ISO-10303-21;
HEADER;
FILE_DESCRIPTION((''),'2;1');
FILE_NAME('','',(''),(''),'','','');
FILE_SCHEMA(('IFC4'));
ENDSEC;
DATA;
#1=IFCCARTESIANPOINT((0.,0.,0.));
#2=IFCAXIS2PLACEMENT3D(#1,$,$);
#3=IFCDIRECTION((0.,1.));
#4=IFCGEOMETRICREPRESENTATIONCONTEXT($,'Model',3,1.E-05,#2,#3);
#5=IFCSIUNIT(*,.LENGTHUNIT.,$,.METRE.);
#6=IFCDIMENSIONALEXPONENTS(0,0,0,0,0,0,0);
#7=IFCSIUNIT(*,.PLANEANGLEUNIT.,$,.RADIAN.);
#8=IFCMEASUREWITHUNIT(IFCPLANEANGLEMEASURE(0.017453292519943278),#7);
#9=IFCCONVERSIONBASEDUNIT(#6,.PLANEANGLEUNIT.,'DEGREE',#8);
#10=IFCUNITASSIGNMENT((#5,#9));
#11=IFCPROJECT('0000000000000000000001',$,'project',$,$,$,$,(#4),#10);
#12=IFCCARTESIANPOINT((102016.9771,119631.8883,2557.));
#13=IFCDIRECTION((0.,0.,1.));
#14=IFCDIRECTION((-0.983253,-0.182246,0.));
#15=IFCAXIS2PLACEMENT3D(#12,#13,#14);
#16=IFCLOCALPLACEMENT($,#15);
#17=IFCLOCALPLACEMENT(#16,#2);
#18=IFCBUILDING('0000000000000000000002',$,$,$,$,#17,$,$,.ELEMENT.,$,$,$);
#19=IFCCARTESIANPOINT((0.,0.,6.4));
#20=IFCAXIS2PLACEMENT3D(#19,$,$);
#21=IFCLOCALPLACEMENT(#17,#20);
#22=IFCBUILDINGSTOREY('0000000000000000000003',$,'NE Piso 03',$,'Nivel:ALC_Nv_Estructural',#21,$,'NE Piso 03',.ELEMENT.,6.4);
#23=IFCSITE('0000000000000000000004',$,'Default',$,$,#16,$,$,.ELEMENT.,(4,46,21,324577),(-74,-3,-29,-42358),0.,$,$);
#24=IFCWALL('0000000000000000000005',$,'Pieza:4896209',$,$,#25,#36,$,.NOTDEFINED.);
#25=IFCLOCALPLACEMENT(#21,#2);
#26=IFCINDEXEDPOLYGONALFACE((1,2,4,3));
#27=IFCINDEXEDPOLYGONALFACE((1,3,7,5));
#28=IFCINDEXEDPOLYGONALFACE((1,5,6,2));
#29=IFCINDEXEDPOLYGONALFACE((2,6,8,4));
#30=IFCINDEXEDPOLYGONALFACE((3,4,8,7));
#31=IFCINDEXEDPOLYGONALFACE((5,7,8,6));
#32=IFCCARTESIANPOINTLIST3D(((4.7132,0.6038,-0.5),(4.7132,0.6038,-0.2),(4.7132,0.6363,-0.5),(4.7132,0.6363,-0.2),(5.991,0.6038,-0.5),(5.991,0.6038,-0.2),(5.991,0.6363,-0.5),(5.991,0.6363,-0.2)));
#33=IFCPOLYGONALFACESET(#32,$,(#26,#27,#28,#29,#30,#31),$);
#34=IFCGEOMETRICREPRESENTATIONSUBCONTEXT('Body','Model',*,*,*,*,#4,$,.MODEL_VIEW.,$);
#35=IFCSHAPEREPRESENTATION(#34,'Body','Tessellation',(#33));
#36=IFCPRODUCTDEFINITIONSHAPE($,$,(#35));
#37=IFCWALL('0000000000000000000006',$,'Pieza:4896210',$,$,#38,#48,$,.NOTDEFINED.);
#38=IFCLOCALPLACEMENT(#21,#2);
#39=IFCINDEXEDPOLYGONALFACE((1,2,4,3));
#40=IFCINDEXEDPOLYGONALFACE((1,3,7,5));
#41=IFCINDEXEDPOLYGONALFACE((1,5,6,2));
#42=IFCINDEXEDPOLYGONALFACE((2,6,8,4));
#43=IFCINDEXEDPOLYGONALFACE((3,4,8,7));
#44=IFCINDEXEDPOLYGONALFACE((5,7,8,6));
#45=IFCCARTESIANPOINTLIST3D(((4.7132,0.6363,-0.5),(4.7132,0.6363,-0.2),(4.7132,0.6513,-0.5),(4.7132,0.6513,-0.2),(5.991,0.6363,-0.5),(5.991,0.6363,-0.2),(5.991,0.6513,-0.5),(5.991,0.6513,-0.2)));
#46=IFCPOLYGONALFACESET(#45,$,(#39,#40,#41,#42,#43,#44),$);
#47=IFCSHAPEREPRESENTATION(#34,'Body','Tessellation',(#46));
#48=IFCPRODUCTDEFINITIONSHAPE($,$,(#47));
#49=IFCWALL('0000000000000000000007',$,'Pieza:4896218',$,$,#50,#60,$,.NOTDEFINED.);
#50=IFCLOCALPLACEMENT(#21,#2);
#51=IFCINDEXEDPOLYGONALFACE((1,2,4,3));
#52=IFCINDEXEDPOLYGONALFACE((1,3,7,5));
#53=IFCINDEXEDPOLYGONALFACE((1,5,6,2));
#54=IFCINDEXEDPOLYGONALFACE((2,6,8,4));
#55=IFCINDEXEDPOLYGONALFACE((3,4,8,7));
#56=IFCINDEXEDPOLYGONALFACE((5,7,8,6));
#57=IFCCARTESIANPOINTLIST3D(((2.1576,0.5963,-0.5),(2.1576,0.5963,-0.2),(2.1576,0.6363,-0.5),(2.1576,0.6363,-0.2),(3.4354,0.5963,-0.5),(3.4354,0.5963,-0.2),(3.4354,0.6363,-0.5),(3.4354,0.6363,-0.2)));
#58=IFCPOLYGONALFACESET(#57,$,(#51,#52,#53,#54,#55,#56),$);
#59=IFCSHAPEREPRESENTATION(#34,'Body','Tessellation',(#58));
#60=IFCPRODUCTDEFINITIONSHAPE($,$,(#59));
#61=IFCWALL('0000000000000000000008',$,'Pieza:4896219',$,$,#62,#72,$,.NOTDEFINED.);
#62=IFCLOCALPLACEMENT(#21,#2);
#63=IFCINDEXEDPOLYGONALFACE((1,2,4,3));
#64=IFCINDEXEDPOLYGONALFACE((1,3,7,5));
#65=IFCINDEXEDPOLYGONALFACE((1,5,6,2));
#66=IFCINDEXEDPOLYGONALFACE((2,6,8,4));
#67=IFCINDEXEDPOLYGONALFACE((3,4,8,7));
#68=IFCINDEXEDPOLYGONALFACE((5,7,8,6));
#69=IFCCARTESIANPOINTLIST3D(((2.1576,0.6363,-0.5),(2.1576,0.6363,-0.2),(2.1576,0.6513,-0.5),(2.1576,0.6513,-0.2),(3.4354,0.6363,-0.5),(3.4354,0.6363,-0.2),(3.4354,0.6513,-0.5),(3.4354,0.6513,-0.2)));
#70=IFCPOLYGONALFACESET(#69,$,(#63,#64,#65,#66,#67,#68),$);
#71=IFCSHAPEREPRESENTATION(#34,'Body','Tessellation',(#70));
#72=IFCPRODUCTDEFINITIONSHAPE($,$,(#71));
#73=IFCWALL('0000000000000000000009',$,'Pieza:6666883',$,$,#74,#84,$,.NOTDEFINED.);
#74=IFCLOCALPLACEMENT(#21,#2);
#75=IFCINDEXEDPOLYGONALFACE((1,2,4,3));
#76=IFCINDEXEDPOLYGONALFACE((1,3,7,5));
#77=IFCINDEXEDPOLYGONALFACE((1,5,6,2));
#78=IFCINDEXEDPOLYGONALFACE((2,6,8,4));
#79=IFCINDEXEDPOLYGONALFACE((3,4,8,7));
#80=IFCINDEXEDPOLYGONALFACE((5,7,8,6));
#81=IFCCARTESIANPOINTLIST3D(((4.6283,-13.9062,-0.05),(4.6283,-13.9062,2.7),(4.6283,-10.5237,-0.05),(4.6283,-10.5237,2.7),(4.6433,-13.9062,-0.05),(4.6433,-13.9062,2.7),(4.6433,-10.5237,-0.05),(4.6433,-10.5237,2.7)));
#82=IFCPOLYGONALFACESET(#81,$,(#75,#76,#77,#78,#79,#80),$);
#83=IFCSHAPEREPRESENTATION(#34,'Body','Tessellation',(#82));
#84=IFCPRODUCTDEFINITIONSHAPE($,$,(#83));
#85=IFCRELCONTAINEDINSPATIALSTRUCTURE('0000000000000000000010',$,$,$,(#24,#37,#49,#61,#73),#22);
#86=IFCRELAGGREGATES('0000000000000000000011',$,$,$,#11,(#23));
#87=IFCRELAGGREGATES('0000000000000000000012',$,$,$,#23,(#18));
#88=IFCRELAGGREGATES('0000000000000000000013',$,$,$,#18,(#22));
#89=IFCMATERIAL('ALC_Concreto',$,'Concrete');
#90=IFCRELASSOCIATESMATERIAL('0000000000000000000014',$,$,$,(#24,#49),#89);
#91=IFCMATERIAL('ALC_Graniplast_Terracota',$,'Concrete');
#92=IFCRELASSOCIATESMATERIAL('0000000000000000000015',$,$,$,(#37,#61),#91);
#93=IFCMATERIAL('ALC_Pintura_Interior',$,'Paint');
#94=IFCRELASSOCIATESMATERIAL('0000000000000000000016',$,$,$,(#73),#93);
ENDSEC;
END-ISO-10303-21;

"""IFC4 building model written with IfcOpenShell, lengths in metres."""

from ifc_helpers import new_model, entity, si_unit, converted_unit, direction, frame, frame_2d, origin, origin_2d_with_axis, place, context, subcontext, project, spatial, rectangle, extrude, material, element, save


model = new_model("IFC4")

# Units and contexts
model_context = context("Model", 3, precision=1e-05, world=origin(), true_north=direction((0.0, 1.0)))
body_context = subcontext(model_context, "Body", "Model", "MODEL_VIEW")
ifc_project = project(units=[si_unit("LENGTHUNIT", "METRE"), converted_unit("PLANEANGLEUNIT", "DEGREE", entity("IfcPlaneAngleMeasure", 0.017453292519943278), si_unit("PLANEANGLEUNIT", "RADIAN"), dimensions=[0, 0, 0, 0, 0, 0, 0])], contexts=[model_context])

# Site, building, storey
site_placement = place(None, frame((102016.9771, 119631.8883, 2557.0), z_axis=(0.0, 0.0, 1.0), x_axis=(-0.983253, -0.182246, 0.0)))
site = spatial("IfcSite", under=ifc_project, at=site_placement, Name="Default", CompositionType="ELEMENT", RefLatitude=(4, 46, 21, 324577), RefLongitude=(-74, -3, -29, -42358), RefElevation=0.0)
building_placement = place(site_placement, origin())
building = spatial("IfcBuilding", under=site, at=building_placement, CompositionType="ELEMENT")
storey_placement = place(building_placement, frame((0.0, 0.0, 6.4)))
storey = spatial("IfcBuildingStorey", under=building, at=storey_placement, Name="NE Piso 03", ObjectType="Nivel:ALC_Nv_Estructural", LongName="NE Piso 03", CompositionType="ELEMENT", Elevation=6.4)

# Walls
ifc_material_1 = material(Name="ALC_Pintura_Interior", Category="Paint")
ifc_material_2 = material(Name="ALC_Concreto", Category="Concrete")
ifc_material_3 = material(Name="ALC_Graniplast_Terracota", Category="Concrete")
wall_1_placement = place(storey_placement, frame((0.0, 0.0, -0.5)))
element("IfcWall", 1, at=wall_1_placement, inside=storey, material=ifc_material_2, Name="Pieza:4896209", PredefinedType="NOTDEFINED", context=body_context, shape_type="SweptSolid", body=[
    extrude(rectangle(XDim=0.0325, YDim=1.2778, at=frame_2d((0.0, 0.0), x_axis=(1.0, 0.0))), frame((5.3521, 0.6201, 0.0), z_axis=(0.0, 0.0, 1.0), x_axis=(0.0, -1.0, 0.0)), (0.0, 0.0, 1.0), 0.3),
])
wall_2_placement = place(storey_placement, frame((0.0, 0.0, -0.5)))
element("IfcWall", 2, at=wall_2_placement, inside=storey, material=ifc_material_3, Name="Pieza:4896210", PredefinedType="NOTDEFINED", context=body_context, shape_type="SweptSolid", body=[
    extrude(rectangle(XDim=0.015, YDim=1.2778, at=origin_2d_with_axis()), frame((5.3521, 0.6438, 0.0), z_axis=(0.0, 0.0, 1.0), x_axis=(0.0, -1.0, 0.0)), (0.0, 0.0, 1.0), 0.3),
])
wall_3_placement = place(storey_placement, frame((0.0, 0.0, -0.5)))
element("IfcWall", 3, at=wall_3_placement, inside=storey, material=ifc_material_2, Name="Pieza:4896218", PredefinedType="NOTDEFINED", context=body_context, shape_type="SweptSolid", body=[
    extrude(rectangle(XDim=0.04, YDim=1.2778, at=frame_2d((0.0, 0.0), x_axis=(1.0, 0.0))), frame((2.7965, 0.6163, 0.0), z_axis=(0.0, 0.0, 1.0), x_axis=(0.0, -1.0, 0.0)), (0.0, 0.0, 1.0), 0.3),
])
wall_4_placement = place(storey_placement, frame((0.0, 0.0, -0.5)))
element("IfcWall", 4, at=wall_4_placement, inside=storey, material=ifc_material_3, Name="Pieza:4896219", PredefinedType="NOTDEFINED", context=body_context, shape_type="SweptSolid", body=[
    extrude(rectangle(XDim=0.015, YDim=1.2778, at=frame_2d((0.0, 0.0), x_axis=(1.0, 0.0))), frame((2.7965, 0.6438, 0.0), z_axis=(0.0, 0.0, 1.0), x_axis=(0.0, -1.0, 0.0)), (0.0, 0.0, 1.0), 0.3),
])
wall_5_placement = place(storey_placement, frame((0.0, 0.0, -0.05)))
element("IfcWall", 5, at=wall_5_placement, inside=storey, material=ifc_material_1, Name="Pieza:6666883", PredefinedType="NOTDEFINED", context=body_context, shape_type="SweptSolid", body=[
    extrude(rectangle(XDim=3.3825, YDim=0.015, at=frame_2d((0.0, 0.0), x_axis=(1.0, 0.0))), frame((4.6358, -12.2149, 0.0), z_axis=(0.0, 0.0, 1.0), x_axis=(0.0, -1.0, 0.0)), (0.0, 0.0, 1.0), 2.75),
])

save(model, "model.ifc")
